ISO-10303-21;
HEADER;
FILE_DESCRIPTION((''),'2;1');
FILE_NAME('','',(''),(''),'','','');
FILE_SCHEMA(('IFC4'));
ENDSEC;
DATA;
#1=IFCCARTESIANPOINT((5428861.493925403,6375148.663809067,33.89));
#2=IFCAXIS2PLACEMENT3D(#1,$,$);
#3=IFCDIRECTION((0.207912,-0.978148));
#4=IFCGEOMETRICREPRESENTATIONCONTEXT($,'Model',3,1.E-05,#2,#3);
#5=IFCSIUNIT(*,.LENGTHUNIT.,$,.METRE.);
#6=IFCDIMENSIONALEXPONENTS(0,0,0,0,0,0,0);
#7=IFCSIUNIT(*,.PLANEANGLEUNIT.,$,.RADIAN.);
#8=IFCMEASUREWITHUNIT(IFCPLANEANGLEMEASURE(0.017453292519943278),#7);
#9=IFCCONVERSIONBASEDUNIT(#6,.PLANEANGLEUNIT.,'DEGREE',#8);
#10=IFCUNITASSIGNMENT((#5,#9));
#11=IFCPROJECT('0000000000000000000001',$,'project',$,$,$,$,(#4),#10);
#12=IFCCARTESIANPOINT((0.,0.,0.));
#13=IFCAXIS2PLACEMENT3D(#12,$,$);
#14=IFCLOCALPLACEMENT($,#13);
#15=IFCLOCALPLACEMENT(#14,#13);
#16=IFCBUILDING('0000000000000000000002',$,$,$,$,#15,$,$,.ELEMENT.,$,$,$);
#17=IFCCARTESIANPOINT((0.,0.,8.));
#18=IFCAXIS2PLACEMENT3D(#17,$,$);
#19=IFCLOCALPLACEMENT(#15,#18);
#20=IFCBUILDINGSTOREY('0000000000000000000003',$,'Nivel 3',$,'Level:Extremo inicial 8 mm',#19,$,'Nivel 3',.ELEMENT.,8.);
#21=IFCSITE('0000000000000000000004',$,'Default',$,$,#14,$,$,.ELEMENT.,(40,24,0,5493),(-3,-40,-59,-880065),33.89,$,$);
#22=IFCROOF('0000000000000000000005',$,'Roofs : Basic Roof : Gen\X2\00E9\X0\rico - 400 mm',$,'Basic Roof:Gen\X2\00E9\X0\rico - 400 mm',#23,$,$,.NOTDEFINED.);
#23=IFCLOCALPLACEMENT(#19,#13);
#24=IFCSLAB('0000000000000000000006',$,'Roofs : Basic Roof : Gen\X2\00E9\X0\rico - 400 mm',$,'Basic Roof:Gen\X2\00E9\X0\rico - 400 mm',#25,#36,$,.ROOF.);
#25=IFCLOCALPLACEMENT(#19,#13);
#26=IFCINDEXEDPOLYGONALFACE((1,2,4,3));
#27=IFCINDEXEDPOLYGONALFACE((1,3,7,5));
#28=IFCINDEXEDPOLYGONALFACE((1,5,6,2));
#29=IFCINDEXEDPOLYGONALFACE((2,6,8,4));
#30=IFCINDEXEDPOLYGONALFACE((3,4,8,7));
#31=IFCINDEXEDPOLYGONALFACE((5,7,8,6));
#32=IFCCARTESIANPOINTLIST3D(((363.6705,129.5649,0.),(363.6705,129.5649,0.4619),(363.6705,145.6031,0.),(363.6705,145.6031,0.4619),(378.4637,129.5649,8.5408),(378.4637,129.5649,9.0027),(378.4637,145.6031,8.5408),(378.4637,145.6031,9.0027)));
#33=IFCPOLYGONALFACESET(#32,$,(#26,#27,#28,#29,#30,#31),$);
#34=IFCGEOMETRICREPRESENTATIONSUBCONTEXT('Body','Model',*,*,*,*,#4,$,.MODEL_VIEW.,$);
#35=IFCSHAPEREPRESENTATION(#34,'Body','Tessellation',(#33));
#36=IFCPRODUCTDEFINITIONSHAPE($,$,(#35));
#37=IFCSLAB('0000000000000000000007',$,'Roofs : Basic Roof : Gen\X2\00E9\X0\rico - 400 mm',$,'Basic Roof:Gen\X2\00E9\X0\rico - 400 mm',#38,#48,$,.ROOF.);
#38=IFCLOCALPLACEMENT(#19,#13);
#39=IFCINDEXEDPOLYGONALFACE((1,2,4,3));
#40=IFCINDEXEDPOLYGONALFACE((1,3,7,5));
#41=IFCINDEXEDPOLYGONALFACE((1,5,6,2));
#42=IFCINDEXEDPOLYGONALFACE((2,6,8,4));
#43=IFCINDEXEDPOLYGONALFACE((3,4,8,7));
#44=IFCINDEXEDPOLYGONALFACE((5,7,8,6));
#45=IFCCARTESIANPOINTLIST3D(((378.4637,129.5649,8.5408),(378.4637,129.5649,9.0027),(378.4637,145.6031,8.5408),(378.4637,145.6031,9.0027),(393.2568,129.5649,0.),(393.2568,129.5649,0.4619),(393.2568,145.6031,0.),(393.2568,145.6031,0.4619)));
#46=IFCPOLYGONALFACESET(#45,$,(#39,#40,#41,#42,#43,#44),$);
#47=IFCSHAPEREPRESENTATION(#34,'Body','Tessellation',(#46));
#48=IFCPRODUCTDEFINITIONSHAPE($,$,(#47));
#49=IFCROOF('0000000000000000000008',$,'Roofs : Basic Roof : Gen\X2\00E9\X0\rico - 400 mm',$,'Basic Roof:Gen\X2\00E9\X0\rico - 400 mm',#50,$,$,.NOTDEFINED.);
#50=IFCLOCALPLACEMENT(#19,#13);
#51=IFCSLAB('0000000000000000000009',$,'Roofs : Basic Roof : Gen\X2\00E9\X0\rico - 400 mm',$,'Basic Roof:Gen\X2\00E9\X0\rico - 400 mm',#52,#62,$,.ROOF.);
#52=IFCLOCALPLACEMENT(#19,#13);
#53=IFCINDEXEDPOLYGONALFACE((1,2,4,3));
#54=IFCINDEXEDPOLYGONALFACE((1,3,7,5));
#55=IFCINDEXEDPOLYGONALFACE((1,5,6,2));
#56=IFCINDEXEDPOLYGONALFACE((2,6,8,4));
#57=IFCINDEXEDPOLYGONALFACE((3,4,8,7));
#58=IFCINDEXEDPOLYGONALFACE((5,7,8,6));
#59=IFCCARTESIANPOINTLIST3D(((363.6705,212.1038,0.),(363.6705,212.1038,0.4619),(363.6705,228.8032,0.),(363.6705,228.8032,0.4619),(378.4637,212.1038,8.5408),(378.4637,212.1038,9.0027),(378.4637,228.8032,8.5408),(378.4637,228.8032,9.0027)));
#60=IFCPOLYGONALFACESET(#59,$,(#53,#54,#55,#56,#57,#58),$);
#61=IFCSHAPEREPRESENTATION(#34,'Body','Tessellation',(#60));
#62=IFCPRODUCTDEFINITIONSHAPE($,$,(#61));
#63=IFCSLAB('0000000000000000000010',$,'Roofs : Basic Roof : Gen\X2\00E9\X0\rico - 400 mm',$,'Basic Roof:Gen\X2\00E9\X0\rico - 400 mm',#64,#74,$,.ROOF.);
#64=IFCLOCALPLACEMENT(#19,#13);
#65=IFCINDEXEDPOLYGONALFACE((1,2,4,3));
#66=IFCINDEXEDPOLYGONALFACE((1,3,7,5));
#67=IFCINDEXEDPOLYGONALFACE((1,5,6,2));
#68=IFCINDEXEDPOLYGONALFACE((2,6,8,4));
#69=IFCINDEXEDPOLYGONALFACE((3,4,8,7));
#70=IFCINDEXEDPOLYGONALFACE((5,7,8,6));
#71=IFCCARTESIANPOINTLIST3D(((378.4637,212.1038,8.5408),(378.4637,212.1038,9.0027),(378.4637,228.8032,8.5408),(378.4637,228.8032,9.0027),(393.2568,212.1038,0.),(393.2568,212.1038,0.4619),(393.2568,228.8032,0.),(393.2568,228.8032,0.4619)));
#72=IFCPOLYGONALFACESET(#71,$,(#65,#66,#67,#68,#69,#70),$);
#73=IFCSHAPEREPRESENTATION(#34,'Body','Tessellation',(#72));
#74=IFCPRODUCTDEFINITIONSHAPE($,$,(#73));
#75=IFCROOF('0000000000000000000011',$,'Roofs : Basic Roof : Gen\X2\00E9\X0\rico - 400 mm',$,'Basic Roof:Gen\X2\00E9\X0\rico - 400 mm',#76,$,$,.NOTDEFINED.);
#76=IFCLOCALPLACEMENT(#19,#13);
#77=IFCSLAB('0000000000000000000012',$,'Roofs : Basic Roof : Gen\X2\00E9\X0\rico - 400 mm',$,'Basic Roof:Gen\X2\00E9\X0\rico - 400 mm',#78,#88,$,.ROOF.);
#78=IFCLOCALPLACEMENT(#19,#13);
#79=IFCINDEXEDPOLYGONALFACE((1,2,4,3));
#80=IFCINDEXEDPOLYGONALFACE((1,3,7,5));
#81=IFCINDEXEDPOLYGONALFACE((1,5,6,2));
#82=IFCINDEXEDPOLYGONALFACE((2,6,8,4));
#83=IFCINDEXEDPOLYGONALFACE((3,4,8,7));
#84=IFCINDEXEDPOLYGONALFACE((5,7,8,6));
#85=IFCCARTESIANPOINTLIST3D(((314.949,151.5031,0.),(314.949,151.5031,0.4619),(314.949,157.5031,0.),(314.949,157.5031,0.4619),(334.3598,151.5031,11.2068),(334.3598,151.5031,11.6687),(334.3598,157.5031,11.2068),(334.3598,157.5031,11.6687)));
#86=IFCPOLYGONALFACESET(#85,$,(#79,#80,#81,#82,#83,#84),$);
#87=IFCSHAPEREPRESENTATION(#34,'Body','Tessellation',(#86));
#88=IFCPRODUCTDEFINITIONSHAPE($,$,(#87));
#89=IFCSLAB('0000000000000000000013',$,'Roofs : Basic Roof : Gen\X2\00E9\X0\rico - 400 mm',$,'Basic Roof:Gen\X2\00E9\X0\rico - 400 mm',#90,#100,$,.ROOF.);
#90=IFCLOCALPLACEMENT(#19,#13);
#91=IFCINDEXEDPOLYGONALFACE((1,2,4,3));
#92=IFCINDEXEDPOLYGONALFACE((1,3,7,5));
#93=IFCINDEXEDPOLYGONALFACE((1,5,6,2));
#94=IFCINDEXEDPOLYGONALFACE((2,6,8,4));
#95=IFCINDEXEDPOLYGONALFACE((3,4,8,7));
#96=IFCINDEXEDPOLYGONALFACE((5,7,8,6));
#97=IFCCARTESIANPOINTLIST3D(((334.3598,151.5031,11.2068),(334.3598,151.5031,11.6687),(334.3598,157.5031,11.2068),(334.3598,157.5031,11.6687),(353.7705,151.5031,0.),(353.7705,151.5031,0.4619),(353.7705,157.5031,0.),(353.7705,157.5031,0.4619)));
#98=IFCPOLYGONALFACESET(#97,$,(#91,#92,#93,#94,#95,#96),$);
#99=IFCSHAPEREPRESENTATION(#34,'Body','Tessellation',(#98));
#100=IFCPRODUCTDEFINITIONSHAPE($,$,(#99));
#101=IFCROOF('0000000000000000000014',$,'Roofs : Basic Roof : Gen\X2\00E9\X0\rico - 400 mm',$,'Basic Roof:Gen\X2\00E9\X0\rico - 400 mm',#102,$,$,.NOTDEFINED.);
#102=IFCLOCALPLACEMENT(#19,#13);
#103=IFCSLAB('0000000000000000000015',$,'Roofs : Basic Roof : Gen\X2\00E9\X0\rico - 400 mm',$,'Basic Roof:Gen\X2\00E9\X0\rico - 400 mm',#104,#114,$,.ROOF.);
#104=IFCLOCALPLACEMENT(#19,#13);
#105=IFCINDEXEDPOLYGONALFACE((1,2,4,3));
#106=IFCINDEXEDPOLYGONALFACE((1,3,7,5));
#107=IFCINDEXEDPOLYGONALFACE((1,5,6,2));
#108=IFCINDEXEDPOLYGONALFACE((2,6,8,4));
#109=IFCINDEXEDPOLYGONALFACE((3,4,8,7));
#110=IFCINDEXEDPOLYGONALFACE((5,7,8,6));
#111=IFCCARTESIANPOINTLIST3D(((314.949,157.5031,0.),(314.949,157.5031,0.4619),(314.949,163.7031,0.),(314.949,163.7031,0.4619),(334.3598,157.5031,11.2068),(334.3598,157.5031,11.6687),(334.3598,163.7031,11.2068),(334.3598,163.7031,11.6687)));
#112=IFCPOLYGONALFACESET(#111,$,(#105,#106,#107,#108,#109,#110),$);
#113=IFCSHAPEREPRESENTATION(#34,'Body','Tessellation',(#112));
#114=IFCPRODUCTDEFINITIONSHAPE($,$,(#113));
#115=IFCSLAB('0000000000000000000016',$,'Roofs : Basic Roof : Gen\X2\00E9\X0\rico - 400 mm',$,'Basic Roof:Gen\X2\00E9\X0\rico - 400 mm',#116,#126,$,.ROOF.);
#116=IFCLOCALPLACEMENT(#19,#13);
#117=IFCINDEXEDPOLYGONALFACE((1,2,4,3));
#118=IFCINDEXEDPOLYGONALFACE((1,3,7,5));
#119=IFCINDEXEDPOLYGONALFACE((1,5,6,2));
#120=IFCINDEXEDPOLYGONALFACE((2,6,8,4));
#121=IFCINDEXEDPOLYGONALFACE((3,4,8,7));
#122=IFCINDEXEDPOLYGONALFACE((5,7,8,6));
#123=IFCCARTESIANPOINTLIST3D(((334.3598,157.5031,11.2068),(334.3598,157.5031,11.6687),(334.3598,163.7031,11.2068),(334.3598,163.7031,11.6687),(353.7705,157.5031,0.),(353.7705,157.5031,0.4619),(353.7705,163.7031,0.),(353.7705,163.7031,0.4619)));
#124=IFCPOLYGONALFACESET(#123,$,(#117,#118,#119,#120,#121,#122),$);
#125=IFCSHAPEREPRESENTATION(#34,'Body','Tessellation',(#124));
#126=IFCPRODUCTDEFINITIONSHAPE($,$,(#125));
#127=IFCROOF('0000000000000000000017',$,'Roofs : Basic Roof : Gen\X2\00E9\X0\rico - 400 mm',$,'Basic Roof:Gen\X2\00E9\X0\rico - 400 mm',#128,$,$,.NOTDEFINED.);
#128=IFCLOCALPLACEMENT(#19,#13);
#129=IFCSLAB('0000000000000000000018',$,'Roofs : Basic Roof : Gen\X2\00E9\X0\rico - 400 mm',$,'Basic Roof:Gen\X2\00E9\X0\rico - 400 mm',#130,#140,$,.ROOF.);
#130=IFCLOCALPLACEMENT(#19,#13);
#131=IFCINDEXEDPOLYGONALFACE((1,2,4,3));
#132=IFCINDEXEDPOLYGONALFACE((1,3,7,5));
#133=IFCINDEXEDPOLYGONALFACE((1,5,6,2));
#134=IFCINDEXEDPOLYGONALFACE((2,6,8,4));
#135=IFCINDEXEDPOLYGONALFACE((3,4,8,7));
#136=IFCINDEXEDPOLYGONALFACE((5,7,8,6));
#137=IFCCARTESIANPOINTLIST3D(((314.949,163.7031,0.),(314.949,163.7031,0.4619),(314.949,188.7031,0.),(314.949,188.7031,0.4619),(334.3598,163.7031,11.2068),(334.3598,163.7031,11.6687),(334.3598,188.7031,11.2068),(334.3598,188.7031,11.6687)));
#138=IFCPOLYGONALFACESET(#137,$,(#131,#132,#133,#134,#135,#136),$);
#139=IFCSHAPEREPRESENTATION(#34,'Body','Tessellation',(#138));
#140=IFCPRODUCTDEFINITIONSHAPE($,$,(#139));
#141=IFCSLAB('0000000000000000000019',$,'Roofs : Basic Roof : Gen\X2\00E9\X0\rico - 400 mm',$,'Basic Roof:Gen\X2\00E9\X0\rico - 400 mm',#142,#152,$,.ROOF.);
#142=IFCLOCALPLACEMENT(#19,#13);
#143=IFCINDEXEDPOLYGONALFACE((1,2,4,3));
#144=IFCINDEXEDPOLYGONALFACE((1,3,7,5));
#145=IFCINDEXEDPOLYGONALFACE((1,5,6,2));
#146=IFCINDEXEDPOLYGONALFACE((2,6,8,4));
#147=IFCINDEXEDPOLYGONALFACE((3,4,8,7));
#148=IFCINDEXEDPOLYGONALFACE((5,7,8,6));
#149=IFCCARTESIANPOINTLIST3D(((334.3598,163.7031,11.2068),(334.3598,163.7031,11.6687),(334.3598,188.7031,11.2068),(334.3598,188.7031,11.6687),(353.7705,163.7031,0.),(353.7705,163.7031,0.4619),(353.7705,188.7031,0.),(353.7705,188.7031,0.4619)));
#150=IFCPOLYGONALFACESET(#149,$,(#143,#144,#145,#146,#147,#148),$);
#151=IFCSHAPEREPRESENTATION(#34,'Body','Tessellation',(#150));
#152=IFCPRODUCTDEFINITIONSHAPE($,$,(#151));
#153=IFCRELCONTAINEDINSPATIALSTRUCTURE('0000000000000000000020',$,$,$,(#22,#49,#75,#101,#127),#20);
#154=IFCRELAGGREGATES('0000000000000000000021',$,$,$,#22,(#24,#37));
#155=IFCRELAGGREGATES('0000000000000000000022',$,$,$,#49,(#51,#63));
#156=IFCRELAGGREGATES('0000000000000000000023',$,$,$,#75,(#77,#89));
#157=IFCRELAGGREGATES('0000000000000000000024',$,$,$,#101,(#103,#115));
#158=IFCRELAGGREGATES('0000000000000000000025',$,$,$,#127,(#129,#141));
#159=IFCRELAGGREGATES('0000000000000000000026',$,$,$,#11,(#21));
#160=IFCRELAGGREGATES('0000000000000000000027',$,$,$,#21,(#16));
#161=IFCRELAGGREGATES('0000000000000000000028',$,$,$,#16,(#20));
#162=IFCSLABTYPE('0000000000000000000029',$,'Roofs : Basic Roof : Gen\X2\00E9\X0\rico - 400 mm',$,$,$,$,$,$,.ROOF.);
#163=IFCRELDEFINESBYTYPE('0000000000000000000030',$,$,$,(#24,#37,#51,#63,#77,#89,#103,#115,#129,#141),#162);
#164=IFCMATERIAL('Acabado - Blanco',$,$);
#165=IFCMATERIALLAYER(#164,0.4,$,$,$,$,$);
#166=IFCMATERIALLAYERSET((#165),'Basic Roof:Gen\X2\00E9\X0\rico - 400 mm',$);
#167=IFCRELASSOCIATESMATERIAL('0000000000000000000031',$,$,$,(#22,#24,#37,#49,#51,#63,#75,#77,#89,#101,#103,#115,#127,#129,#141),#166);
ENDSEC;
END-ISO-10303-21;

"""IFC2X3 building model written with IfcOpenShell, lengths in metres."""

from ifc_helpers import new_model, entity, si_unit, converted_unit, direction, frame, frame_2d, origin, origin_2d_with_axis, place, context, subcontext, project, spatial, rectangle, extrude, material, layer, layer_set, type_object, element, aggregate, save


model = new_model("IFC2X3")

# Units and contexts
model_context = context("Model", 3, precision=1e-05, world=frame((5428861.493925403, 6375148.663809067, 33.89)), true_north=direction((0.207912, -0.978148)))
body_context = subcontext(model_context, "Body", "Model", "MODEL_VIEW")
ifc_project = project(units=[si_unit("LENGTHUNIT", "METRE"), converted_unit("PLANEANGLEUNIT", "DEGREE", entity("IfcPlaneAngleMeasure", 0.017453292519943278), si_unit("PLANEANGLEUNIT", "RADIAN"), dimensions=[0, 0, 0, 0, 0, 0, 0])], contexts=[model_context])

# Site, building, storey
site_placement = place(None, origin())
site = spatial("IfcSite", under=ifc_project, at=site_placement, Name="Default", CompositionType="ELEMENT", RefLatitude=(40, 24, 0, 5493), RefLongitude=(-3, -40, -59, -880065), RefElevation=33.89)
building_placement = place(site_placement, origin())
building = spatial("IfcBuilding", under=site, at=building_placement, CompositionType="ELEMENT")
storey_placement = place(building_placement, frame((0.0, 0.0, 8.0)))
storey = spatial("IfcBuildingStorey", under=building, at=storey_placement, Name="Nivel 3", ObjectType="Level:Extremo inicial 8 mm", LongName="Nivel 3", CompositionType="ELEMENT", Elevation=8.0)

# Shared definitions
ifc_material = material(Name="Acabado - Blanco")
ifc_layer = layer(ifc_material, 0.4)
ifc_layer_set = layer_set([ifc_layer], Name="Basic Roof:Genérico - 400 mm")
slab_type = type_object("IfcSlabType", Name="Roofs : Basic Roof : Genérico - 400 mm", PredefinedType="ROOF")

# Roofs, slabs
roof_1_placement = place(storey_placement, frame((363.6705, 129.5649, 0.0)))
roof_1 = element("IfcRoof", 1, at=roof_1_placement, inside=storey, material=ifc_layer_set, Name="Roofs : Basic Roof : Genérico - 400 mm", ObjectType="Basic Roof:Genérico - 400 mm", ShapeType="NOTDEFINED")
slab_1_placement = place(roof_1_placement, origin())
slab_1 = element("IfcSlab", 2, at=slab_1_placement, type_object=slab_type, material=ifc_layer_set, Name="Roofs : Basic Roof : Genérico - 400 mm", ObjectType="Basic Roof:Genérico - 400 mm", PredefinedType="ROOF", context=body_context, shape_type="SweptSolid", body=[
    extrude(rectangle(XDim=16.0382, YDim=17.0816, at=frame_2d((0.0, 0.0), x_axis=(0.0, 1.0))), frame((7.3966, 8.0191, 4.2704), z_axis=(-0.5, 0.0, 0.866025), x_axis=(0.866025, 0.0, 0.5)), (0.5, 0.0, 0.866025), 0.4619),
])
slab_2_placement = place(roof_1_placement, origin())
slab_2 = element("IfcSlab", 3, at=slab_2_placement, type_object=slab_type, material=ifc_layer_set, Name="Roofs : Basic Roof : Genérico - 400 mm", ObjectType="Basic Roof:Genérico - 400 mm", PredefinedType="ROOF", context=body_context, shape_type="SweptSolid", body=[
    extrude(rectangle(XDim=17.0816, YDim=16.0382, at=origin_2d_with_axis()), frame((22.1897, 8.0191, 4.2704), z_axis=(0.5, 0.0, 0.866025), x_axis=(0.866025, 0.0, -0.5)), (-0.5, 0.0, 0.866025), 0.4619),
])
aggregate(roof_1, [slab_1, slab_2])
roof_2_placement = place(storey_placement, frame((363.6705, 212.1038, 0.0)))
roof_2 = element("IfcRoof", 4, at=roof_2_placement, inside=storey, material=ifc_layer_set, Name="Roofs : Basic Roof : Genérico - 400 mm", ObjectType="Basic Roof:Genérico - 400 mm", ShapeType="NOTDEFINED")
slab_3_placement = place(roof_2_placement, origin())
slab_3 = element("IfcSlab", 5, at=slab_3_placement, type_object=slab_type, material=ifc_layer_set, Name="Roofs : Basic Roof : Genérico - 400 mm", ObjectType="Basic Roof:Genérico - 400 mm", PredefinedType="ROOF", context=body_context, shape_type="SweptSolid", body=[
    extrude(rectangle(XDim=16.6993, YDim=17.0816, at=frame_2d((0.0, 0.0), x_axis=(0.0, 1.0))), frame((7.3966, 8.3497, 4.2704), z_axis=(-0.5, 0.0, 0.866025), x_axis=(0.866025, 0.0, 0.5)), (0.5, 0.0, 0.866025), 0.4619),
])
slab_4_placement = place(roof_2_placement, origin())
slab_4 = element("IfcSlab", 6, at=slab_4_placement, type_object=slab_type, material=ifc_layer_set, Name="Roofs : Basic Roof : Genérico - 400 mm", ObjectType="Basic Roof:Genérico - 400 mm", PredefinedType="ROOF", context=body_context, shape_type="SweptSolid", body=[
    extrude(rectangle(XDim=17.0816, YDim=16.6993, at=frame_2d((0.0, 0.0), x_axis=(1.0, 0.0))), frame((22.1897, 8.3497, 4.2704), z_axis=(0.5, 0.0, 0.866025), x_axis=(0.866025, 0.0, -0.5)), (-0.5, 0.0, 0.866025), 0.4619),
])
aggregate(roof_2, [slab_3, slab_4])
roof_3_placement = place(storey_placement, frame((314.949, 151.5031, 0.0)))
roof_3 = element("IfcRoof", 7, at=roof_3_placement, inside=storey, material=ifc_layer_set, Name="Roofs : Basic Roof : Genérico - 400 mm", ObjectType="Basic Roof:Genérico - 400 mm", ShapeType="NOTDEFINED")
slab_5_placement = place(roof_3_placement, origin())
slab_5 = element("IfcSlab", 8, at=slab_5_placement, type_object=slab_type, material=ifc_layer_set, Name="Roofs : Basic Roof : Genérico - 400 mm", ObjectType="Basic Roof:Genérico - 400 mm", PredefinedType="ROOF", context=body_context, shape_type="SweptSolid", body=[
    extrude(rectangle(XDim=6.0, YDim=22.4136, at=frame_2d((0.0, 0.0), x_axis=(0.0, 1.0))), frame((9.7054, 3.0, 5.6034), z_axis=(-0.5, 0.0, 0.866025), x_axis=(0.866025, 0.0, 0.5)), (0.5, 0.0, 0.866025), 0.4619),
])
slab_6_placement = place(roof_3_placement, origin())
slab_6 = element("IfcSlab", 9, at=slab_6_placement, type_object=slab_type, material=ifc_layer_set, Name="Roofs : Basic Roof : Genérico - 400 mm", ObjectType="Basic Roof:Genérico - 400 mm", PredefinedType="ROOF", context=body_context, shape_type="SweptSolid", body=[
    extrude(rectangle(XDim=22.4136, YDim=6.0, at=frame_2d((0.0, 0.0), x_axis=(1.0, 0.0))), frame((29.1162, 3.0, 5.6034), z_axis=(0.5, 0.0, 0.866025), x_axis=(0.866025, 0.0, -0.5)), (-0.5, 0.0, 0.866025), 0.4619),
])
aggregate(roof_3, [slab_5, slab_6])
roof_4_placement = place(storey_placement, frame((314.949, 157.5031, 0.0)))
roof_4 = element("IfcRoof", 10, at=roof_4_placement, inside=storey, material=ifc_layer_set, Name="Roofs : Basic Roof : Genérico - 400 mm", ObjectType="Basic Roof:Genérico - 400 mm", ShapeType="NOTDEFINED")
slab_7_placement = place(roof_4_placement, origin())
slab_7 = element("IfcSlab", 11, at=slab_7_placement, type_object=slab_type, material=ifc_layer_set, Name="Roofs : Basic Roof : Genérico - 400 mm", ObjectType="Basic Roof:Genérico - 400 mm", PredefinedType="ROOF", context=body_context, shape_type="SweptSolid", body=[
    extrude(rectangle(XDim=6.2, YDim=22.4136, at=frame_2d((0.0, 0.0), x_axis=(0.0, 1.0))), frame((9.7054, 3.1, 5.6034), z_axis=(-0.5, 0.0, 0.866025), x_axis=(0.866025, 0.0, 0.5)), (0.5, 0.0, 0.866025), 0.4619),
])
slab_8_placement = place(roof_4_placement, origin())
slab_8 = element("IfcSlab", 12, at=slab_8_placement, type_object=slab_type, material=ifc_layer_set, Name="Roofs : Basic Roof : Genérico - 400 mm", ObjectType="Basic Roof:Genérico - 400 mm", PredefinedType="ROOF", context=body_context, shape_type="SweptSolid", body=[
    extrude(rectangle(XDim=22.4136, YDim=6.2, at=frame_2d((0.0, 0.0), x_axis=(1.0, 0.0))), frame((29.1162, 3.1, 5.6034), z_axis=(0.5, 0.0, 0.866025), x_axis=(0.866025, 0.0, -0.5)), (-0.5, 0.0, 0.866025), 0.4619),
])
aggregate(roof_4, [slab_7, slab_8])
roof_5_placement = place(storey_placement, frame((314.949, 163.7031, 0.0)))
roof_5 = element("IfcRoof", 13, at=roof_5_placement, inside=storey, material=ifc_layer_set, Name="Roofs : Basic Roof : Genérico - 400 mm", ObjectType="Basic Roof:Genérico - 400 mm", ShapeType="NOTDEFINED")
slab_9_placement = place(roof_5_placement, origin())
slab_9 = element("IfcSlab", 14, at=slab_9_placement, type_object=slab_type, material=ifc_layer_set, Name="Roofs : Basic Roof : Genérico - 400 mm", ObjectType="Basic Roof:Genérico - 400 mm", PredefinedType="ROOF", context=body_context, shape_type="SweptSolid", body=[
    extrude(rectangle(XDim=25.0, YDim=22.4136, at=frame_2d((0.0, 0.0), x_axis=(0.0, 1.0))), frame((9.7054, 12.5, 5.6034), z_axis=(-0.5, 0.0, 0.866025), x_axis=(0.866025, 0.0, 0.5)), (0.5, 0.0, 0.866025), 0.4619),
])
slab_10_placement = place(roof_5_placement, origin())
slab_10 = element("IfcSlab", 15, at=slab_10_placement, type_object=slab_type, material=ifc_layer_set, Name="Roofs : Basic Roof : Genérico - 400 mm", ObjectType="Basic Roof:Genérico - 400 mm", PredefinedType="ROOF", context=body_context, shape_type="SweptSolid", body=[
    extrude(rectangle(XDim=22.4136, YDim=25.0, at=origin_2d_with_axis()), frame((29.1162, 12.5, 5.6034), z_axis=(0.5, 0.0, 0.866025), x_axis=(0.866025, 0.0, -0.5)), (-0.5, 0.0, 0.866025), 0.4619),
])
aggregate(roof_5, [slab_9, slab_10])

save(model, "model.ifc")
